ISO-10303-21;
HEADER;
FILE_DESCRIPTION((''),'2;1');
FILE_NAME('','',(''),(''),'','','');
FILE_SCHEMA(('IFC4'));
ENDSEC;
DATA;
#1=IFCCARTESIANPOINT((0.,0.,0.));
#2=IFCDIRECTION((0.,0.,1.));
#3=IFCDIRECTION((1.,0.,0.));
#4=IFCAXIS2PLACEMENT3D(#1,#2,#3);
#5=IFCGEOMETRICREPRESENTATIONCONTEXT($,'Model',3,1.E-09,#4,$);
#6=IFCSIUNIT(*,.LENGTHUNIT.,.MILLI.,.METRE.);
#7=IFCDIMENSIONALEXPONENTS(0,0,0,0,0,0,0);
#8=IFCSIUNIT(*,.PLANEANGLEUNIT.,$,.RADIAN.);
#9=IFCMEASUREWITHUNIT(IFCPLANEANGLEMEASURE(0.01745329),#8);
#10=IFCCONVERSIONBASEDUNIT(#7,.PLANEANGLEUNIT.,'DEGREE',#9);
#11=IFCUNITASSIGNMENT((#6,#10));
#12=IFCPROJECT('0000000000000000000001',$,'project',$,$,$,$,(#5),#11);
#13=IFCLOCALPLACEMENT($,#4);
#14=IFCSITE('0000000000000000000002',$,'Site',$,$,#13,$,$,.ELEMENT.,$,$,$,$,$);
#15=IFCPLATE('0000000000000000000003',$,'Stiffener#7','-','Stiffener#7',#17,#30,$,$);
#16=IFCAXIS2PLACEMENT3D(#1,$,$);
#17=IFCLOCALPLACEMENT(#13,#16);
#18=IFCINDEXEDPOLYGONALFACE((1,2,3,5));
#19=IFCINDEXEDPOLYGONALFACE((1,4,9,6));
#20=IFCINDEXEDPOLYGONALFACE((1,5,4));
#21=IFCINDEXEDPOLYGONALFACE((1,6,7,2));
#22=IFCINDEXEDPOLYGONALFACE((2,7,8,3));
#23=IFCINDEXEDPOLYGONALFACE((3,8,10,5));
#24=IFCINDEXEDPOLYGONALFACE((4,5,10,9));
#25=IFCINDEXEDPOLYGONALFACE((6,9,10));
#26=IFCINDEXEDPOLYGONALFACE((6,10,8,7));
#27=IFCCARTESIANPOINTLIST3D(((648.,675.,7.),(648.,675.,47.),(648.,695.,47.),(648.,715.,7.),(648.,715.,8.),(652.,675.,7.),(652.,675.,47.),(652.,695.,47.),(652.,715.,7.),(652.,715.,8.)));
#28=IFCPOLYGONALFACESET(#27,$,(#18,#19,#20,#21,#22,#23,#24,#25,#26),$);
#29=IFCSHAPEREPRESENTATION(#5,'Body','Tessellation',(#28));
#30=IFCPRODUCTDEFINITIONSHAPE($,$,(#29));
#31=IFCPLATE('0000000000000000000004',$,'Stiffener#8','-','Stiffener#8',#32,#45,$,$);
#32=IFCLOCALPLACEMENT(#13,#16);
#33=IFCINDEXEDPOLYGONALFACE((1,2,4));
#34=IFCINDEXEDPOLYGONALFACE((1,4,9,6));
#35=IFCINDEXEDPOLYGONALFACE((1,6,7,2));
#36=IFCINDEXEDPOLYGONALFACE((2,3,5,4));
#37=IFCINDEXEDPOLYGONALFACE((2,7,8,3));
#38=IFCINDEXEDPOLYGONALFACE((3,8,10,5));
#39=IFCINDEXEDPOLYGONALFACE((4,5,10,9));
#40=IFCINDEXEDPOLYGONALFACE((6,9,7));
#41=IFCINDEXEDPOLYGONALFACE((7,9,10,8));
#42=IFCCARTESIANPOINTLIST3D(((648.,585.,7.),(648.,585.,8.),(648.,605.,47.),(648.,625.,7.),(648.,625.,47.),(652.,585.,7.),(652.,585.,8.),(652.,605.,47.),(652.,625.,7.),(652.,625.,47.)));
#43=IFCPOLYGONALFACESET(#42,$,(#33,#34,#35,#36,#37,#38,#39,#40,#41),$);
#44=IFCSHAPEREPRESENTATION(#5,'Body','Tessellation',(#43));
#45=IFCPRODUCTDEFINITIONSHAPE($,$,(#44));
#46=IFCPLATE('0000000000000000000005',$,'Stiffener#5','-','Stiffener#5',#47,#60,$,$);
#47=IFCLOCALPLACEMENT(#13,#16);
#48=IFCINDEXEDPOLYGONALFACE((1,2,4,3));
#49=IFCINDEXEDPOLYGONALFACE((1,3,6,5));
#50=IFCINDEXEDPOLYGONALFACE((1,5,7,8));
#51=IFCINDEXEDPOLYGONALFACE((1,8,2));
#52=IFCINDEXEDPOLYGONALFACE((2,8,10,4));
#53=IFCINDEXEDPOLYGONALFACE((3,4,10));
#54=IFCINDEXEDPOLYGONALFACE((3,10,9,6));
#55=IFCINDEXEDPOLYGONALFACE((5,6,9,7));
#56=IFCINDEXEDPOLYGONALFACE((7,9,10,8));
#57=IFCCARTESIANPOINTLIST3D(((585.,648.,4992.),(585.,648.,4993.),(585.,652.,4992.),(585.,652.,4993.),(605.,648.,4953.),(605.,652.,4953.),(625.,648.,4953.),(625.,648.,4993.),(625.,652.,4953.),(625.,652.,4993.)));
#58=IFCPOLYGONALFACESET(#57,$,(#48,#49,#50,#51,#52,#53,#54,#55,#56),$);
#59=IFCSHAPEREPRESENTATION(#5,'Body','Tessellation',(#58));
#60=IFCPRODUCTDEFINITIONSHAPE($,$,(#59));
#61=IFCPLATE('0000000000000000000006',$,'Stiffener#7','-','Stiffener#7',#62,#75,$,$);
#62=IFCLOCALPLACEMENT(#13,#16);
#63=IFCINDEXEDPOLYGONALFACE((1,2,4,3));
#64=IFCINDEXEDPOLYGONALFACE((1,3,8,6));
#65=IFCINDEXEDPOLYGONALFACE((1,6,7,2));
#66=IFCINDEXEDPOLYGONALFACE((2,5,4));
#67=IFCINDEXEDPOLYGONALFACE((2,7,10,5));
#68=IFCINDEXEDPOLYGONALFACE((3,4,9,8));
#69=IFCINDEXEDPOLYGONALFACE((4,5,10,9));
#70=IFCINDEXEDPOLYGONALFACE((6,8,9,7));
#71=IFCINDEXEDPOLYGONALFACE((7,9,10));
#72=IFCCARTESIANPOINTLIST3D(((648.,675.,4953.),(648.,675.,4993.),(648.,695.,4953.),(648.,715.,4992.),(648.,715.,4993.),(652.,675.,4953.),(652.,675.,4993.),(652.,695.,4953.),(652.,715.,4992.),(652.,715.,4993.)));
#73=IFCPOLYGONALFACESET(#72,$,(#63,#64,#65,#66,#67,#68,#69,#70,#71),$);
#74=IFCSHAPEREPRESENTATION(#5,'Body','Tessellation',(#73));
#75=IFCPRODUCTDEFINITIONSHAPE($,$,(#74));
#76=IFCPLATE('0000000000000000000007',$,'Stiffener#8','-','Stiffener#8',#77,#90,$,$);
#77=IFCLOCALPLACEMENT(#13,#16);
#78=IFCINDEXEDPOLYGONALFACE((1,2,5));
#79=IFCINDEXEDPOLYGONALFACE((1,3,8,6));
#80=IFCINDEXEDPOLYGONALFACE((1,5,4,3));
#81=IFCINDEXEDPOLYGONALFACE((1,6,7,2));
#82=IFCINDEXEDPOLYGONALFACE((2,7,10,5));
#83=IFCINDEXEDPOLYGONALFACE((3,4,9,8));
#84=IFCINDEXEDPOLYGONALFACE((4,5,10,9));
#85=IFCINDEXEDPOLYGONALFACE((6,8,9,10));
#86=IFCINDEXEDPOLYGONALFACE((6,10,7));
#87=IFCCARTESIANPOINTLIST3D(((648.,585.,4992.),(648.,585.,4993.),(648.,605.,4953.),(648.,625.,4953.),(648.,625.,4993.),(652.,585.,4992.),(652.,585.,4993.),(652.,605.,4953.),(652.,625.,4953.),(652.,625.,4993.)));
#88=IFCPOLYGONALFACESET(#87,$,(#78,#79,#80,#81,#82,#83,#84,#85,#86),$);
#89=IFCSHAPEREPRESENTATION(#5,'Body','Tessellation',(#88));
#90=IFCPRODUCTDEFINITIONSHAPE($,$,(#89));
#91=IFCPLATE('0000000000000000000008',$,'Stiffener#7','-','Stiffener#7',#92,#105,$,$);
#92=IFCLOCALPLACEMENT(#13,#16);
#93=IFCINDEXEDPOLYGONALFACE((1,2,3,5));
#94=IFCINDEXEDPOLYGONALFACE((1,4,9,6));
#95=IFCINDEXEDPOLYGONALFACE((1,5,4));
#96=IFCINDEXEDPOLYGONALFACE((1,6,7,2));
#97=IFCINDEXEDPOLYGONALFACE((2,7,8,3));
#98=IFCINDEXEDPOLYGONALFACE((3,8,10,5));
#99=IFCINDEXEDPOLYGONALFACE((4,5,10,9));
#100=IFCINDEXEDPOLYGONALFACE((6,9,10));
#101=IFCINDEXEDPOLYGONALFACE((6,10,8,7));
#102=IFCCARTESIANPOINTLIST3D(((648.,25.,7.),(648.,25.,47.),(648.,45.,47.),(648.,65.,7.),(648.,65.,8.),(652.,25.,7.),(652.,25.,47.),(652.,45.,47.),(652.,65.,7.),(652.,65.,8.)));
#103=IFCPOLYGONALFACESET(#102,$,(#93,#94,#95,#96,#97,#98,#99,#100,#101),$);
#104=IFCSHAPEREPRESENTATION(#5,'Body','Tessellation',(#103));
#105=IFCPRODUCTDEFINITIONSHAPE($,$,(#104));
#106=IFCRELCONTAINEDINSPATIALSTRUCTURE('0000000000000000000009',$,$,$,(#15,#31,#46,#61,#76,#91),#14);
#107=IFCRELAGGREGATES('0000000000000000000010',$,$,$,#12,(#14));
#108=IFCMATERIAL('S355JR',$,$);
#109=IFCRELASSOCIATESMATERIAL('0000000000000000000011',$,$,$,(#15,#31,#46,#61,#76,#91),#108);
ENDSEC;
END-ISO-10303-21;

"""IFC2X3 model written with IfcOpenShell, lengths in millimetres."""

from ifc_helpers import new_model, entity, si_unit, converted_unit, frame, origin, origin_with_axes, place, context, project, spatial, polyline, outline, extrude, material, element, save


model = new_model("IFC2X3")

# Units and contexts
model_context = context("Model", 3, precision=1e-09, world=origin_with_axes())
ifc_project = project(units=[si_unit("LENGTHUNIT", "METRE", prefix="MILLI"), converted_unit("PLANEANGLEUNIT", "DEGREE", entity("IfcPlaneAngleMeasure", 0.01745329), si_unit("PLANEANGLEUNIT", "RADIAN"), dimensions=[0, 0, 0, 0, 0, 0, 0])], contexts=[model_context])

# Site
site_placement = place(None, origin_with_axes())
site = spatial("IfcSite", under=ifc_project, at=site_placement, Name="Site", CompositionType="ELEMENT")

# Shared definitions
ifc_material = material(Name="S355JR")

# Plates, openings
plate_1_placement = place(None, frame((652.0, 675.0, 7.0), z_axis=(-1.0, 0.0, 0.0), x_axis=(0.0, 0.0, 1.0)))
plate_1 = element("IfcPlate", 1, at=plate_1_placement, inside=site, material=ifc_material, Name="Stiffener#7", Description="-", ObjectType="Stiffener#7", context=model_context, shape_type="SweptSolid", body=[
    extrude(outline(polyline([(0.0, 0.0), (40.0, 0.0), (40.0, 40.0), (0.0, 40.0), (0.0, 0.0)])), origin_with_axes(), (0.0, 0.0, 1.0), 4.0),
])
opening_1_placement = place(plate_1_placement, frame((0.0, 0.0, 0.0), z_axis=(0.0, 0.0, 1.0), x_axis=(1.0, 0.0, 0.0)))
element("IfcOpeningElement", 2, at=opening_1_placement, cuts=plate_1, ObjectType="Opening", context=model_context, shape_type="SweptSolid", body=[
    extrude(outline(polyline([(40.0, 40.0), (1.0, 40.0), (40.0, 20.0), (40.0, 40.0)])), origin(), (0.0, 0.0, 1.0), 4.0),
])
plate_2_placement = place(None, frame((652.0, 625.0, 7.0), z_axis=(-1.0, 0.0, 0.0), x_axis=(0.0, -1.0, 0.0)))
plate_2 = element("IfcPlate", 3, at=plate_2_placement, inside=site, material=ifc_material, Name="Stiffener#8", Description="-", ObjectType="Stiffener#8", context=model_context, shape_type="SweptSolid", body=[
    extrude(outline(polyline([(0.0, 0.0), (40.0, 0.0), (40.0, 40.0), (0.0, 40.0), (0.0, 0.0)])), origin_with_axes(), (0.0, 0.0, 1.0), 4.0),
])
opening_2_placement = place(plate_2_placement, frame((0.0, 0.0, 0.0), z_axis=(0.0, 0.0, 1.0), x_axis=(1.0, 0.0, 0.0)))
element("IfcOpeningElement", 4, at=opening_2_placement, cuts=plate_2, ObjectType="Opening", context=model_context, shape_type="SweptSolid", body=[
    extrude(outline(polyline([(40.0, 40.0), (20.0, 40.0), (40.0, 1.0), (40.0, 40.0)])), origin(), (0.0, 0.0, 1.0), 4.0),
])
plate_3_placement = place(None, frame((625.0, 648.0, 4993.0), z_axis=(0.0, 1.0, 0.0), x_axis=(0.0, 0.0, -1.0)))
plate_3 = element("IfcPlate", 5, at=plate_3_placement, inside=site, material=ifc_material, Name="Stiffener#5", Description="-", ObjectType="Stiffener#5", context=model_context, shape_type="SweptSolid", body=[
    extrude(outline(polyline([(0.0, 0.0), (40.0, 0.0), (40.0, 40.0), (0.0, 40.0), (0.0, 0.0)])), origin_with_axes(), (0.0, 0.0, 1.0), 4.0),
])
opening_3_placement = place(plate_3_placement, frame((0.0, 0.0, 0.0), z_axis=(0.0, 0.0, 1.0), x_axis=(1.0, 0.0, 0.0)))
element("IfcOpeningElement", 6, at=opening_3_placement, cuts=plate_3, ObjectType="Opening", context=model_context, shape_type="SweptSolid", body=[
    extrude(outline(polyline([(40.0, 40.0), (1.0, 40.0), (40.0, 20.0), (40.0, 40.0)])), origin(), (0.0, 0.0, 1.0), 4.0),
])
plate_4_placement = place(None, frame((648.0, 675.0, 4993.0), z_axis=(1.0, 0.0, 0.0), x_axis=(0.0, 0.0, -1.0)))
plate_4 = element("IfcPlate", 7, at=plate_4_placement, inside=site, material=ifc_material, Name="Stiffener#7", Description="-", ObjectType="Stiffener#7", context=model_context, shape_type="SweptSolid", body=[
    extrude(outline(polyline([(0.0, 0.0), (40.0, 0.0), (40.0, 40.0), (0.0, 40.0), (0.0, 0.0)])), origin_with_axes(), (0.0, 0.0, 1.0), 4.0),
])
opening_4_placement = place(plate_4_placement, frame((0.0, 0.0, 0.0), z_axis=(0.0, 0.0, 1.0), x_axis=(1.0, 0.0, 0.0)))
element("IfcOpeningElement", 8, at=opening_4_placement, cuts=plate_4, ObjectType="Opening", context=model_context, shape_type="SweptSolid", body=[
    extrude(outline(polyline([(40.0, 40.0), (1.0, 40.0), (40.0, 20.0), (40.0, 40.0)])), origin(), (0.0, 0.0, 1.0), 4.0),
])
plate_5_placement = place(None, frame((648.0, 625.0, 4993.0), z_axis=(1.0, 0.0, 0.0), x_axis=(0.0, -1.0, 0.0)))
plate_5 = element("IfcPlate", 9, at=plate_5_placement, inside=site, material=ifc_material, Name="Stiffener#8", Description="-", ObjectType="Stiffener#8", context=model_context, shape_type="SweptSolid", body=[
    extrude(outline(polyline([(0.0, 0.0), (40.0, 0.0), (40.0, 40.0), (0.0, 40.0), (0.0, 0.0)])), origin_with_axes(), (0.0, 0.0, 1.0), 4.0),
])
opening_5_placement = place(plate_5_placement, frame((0.0, 0.0, 0.0), z_axis=(0.0, 0.0, 1.0), x_axis=(1.0, 0.0, 0.0)))
element("IfcOpeningElement", 10, at=opening_5_placement, cuts=plate_5, ObjectType="Opening", context=model_context, shape_type="SweptSolid", body=[
    extrude(outline(polyline([(40.0, 40.0), (20.0, 40.0), (40.0, 1.0), (40.0, 40.0)])), origin(), (0.0, 0.0, 1.0), 4.0),
])
plate_6_placement = place(None, frame((652.0, 25.0, 7.0), z_axis=(-1.0, 0.0, 0.0), x_axis=(0.0, 0.0, 1.0)))
plate_6 = element("IfcPlate", 11, at=plate_6_placement, inside=site, material=ifc_material, Name="Stiffener#7", Description="-", ObjectType="Stiffener#7", context=model_context, shape_type="SweptSolid", body=[
    extrude(outline(polyline([(0.0, 0.0), (40.0, 0.0), (40.0, 40.0), (0.0, 40.0), (0.0, 0.0)])), origin_with_axes(), (0.0, 0.0, 1.0), 4.0),
])
opening_6_placement = place(plate_6_placement, frame((0.0, 0.0, 0.0), z_axis=(0.0, 0.0, 1.0), x_axis=(1.0, 0.0, 0.0)))
element("IfcOpeningElement", 12, at=opening_6_placement, cuts=plate_6, ObjectType="Opening", context=model_context, shape_type="SweptSolid", body=[
    extrude(outline(polyline([(40.0, 40.0), (1.0, 40.0), (40.0, 20.0), (40.0, 40.0)])), origin(), (0.0, 0.0, 1.0), 4.0),
])

save(model, "model.ifc")
